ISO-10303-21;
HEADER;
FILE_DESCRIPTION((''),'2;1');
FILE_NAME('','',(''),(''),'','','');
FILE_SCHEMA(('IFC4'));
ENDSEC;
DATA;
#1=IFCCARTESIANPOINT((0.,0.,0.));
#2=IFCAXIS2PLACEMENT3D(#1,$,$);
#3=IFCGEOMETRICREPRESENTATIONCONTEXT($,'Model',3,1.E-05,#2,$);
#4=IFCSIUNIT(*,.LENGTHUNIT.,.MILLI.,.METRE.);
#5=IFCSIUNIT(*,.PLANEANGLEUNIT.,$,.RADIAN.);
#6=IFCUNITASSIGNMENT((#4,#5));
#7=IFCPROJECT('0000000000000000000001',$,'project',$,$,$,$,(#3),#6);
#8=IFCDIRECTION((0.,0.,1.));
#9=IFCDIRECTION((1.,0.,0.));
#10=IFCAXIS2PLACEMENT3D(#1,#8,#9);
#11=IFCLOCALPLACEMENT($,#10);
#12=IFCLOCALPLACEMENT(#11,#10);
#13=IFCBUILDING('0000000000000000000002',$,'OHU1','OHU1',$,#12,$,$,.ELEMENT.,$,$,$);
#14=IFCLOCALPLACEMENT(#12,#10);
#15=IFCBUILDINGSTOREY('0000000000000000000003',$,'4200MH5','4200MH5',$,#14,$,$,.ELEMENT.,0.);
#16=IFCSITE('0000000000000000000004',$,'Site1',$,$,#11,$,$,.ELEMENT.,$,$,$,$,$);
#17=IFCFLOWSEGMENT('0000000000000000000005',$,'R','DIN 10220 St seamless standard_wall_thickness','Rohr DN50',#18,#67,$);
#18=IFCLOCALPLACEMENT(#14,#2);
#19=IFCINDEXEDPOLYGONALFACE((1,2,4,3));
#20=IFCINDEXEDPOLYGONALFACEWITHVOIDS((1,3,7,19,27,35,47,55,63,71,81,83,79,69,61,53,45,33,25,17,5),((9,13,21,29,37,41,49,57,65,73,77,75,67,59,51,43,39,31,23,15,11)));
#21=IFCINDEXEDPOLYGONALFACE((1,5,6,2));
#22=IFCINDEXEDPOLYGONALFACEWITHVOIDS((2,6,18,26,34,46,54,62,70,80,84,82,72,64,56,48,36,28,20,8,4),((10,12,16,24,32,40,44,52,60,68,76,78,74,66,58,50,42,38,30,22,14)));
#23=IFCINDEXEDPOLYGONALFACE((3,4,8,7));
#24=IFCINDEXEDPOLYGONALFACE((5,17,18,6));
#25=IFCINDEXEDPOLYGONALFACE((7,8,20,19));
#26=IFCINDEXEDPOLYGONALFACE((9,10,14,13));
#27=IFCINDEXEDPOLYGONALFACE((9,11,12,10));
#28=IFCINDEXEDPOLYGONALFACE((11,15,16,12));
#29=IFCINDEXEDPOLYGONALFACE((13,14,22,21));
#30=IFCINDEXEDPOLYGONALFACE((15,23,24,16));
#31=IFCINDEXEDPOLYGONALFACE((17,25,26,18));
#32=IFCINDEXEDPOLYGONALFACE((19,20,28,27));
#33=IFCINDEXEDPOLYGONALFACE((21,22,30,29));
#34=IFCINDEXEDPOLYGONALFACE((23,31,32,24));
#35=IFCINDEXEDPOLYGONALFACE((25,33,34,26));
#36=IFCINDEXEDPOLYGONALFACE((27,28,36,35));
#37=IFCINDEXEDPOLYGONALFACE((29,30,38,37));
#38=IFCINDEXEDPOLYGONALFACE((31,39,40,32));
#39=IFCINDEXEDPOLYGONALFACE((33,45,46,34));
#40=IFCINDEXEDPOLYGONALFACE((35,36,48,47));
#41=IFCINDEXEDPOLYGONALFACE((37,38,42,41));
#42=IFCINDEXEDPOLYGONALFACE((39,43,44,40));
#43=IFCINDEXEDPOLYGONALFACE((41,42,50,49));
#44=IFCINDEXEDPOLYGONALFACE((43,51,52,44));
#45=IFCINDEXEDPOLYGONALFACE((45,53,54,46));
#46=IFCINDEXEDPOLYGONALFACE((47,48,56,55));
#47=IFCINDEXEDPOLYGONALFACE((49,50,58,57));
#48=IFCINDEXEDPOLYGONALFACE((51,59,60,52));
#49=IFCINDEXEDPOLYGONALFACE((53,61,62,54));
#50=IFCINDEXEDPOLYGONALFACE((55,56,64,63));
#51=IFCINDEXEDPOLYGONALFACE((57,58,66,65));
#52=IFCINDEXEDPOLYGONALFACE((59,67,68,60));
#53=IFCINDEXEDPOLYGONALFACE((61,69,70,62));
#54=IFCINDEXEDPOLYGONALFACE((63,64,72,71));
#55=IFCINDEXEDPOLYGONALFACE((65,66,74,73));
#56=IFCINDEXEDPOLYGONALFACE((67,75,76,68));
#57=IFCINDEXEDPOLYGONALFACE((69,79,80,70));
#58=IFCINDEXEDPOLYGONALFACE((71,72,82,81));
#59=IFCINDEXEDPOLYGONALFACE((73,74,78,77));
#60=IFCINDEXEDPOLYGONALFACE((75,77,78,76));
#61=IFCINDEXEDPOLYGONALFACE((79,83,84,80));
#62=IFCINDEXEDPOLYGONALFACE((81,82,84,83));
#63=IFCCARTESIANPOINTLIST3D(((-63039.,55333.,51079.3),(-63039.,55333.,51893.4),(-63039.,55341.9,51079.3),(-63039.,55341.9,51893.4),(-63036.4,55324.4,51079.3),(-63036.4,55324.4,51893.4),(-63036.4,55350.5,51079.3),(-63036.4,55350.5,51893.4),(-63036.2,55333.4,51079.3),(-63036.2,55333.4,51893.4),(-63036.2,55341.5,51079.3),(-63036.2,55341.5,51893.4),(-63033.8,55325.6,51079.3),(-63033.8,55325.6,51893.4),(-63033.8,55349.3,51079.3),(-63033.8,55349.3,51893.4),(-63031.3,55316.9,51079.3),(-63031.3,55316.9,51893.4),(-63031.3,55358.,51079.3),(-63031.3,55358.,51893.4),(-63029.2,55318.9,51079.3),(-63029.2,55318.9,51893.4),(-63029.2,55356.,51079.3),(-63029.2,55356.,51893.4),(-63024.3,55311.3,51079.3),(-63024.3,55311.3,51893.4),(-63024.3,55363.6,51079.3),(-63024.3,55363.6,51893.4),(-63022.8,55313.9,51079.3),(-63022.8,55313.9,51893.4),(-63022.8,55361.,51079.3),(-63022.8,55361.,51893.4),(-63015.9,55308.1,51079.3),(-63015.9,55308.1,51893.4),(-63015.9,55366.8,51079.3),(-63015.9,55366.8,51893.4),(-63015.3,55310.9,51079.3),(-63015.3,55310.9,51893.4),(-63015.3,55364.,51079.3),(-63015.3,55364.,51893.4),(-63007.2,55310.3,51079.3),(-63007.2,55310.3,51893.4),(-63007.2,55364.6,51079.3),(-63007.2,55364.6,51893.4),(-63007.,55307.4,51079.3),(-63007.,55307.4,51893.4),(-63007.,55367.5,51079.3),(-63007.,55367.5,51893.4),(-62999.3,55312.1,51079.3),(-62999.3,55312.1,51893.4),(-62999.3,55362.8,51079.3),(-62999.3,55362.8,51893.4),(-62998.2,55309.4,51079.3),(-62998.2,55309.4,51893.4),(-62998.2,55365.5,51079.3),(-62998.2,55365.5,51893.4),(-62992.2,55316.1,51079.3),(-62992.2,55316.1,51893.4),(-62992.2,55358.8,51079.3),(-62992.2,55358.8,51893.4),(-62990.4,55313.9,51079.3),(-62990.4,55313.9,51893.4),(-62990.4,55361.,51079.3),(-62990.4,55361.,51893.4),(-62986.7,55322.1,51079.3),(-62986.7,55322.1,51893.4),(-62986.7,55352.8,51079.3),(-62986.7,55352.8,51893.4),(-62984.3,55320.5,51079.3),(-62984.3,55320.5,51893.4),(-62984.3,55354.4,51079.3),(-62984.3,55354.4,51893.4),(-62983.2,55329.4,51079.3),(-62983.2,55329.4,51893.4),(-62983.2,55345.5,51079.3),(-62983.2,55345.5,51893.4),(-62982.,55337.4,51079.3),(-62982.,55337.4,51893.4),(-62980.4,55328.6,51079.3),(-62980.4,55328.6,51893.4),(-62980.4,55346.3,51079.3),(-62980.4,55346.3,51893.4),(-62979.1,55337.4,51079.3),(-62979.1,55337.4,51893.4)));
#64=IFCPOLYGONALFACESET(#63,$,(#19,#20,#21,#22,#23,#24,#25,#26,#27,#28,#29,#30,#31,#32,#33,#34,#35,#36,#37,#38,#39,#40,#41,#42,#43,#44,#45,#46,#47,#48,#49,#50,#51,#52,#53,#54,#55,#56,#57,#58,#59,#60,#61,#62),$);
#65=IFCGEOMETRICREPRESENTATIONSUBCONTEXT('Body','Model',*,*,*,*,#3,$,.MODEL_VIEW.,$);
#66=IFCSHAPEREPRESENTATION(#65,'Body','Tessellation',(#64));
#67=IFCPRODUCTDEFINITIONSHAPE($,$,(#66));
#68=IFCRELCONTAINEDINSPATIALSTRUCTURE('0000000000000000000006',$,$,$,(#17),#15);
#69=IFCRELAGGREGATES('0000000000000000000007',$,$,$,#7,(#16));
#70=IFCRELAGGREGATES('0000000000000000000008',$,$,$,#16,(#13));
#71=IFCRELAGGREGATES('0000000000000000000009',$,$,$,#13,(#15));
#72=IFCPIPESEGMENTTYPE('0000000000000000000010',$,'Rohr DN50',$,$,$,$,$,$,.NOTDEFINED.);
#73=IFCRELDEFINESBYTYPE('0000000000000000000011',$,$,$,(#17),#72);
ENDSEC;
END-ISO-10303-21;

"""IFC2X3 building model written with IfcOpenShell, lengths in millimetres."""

from ifc_helpers import new_model, si_unit, frame, origin, origin_with_axes, origin_2d_with_axis, place, context, subcontext, project, spatial, hollow_circle, extrude, type_object, element, save


model = new_model("IFC2X3")

# Units and contexts
model_context = context("Model", 3, precision=1e-05, world=origin())
body_context = subcontext(model_context, "Body", "Model", "MODEL_VIEW")
ifc_project = project(units=[si_unit("LENGTHUNIT", "METRE", prefix="MILLI"), si_unit("PLANEANGLEUNIT", "RADIAN")], contexts=[model_context])

# Site, building, storey
site_placement = place(None, origin_with_axes())
site = spatial("IfcSite", under=ifc_project, at=site_placement, Name="Site1", CompositionType="ELEMENT")
building_placement = place(site_placement, origin_with_axes())
building = spatial("IfcBuilding", under=site, at=building_placement, Name="OHU1", Description="OHU1", CompositionType="ELEMENT")
storey_placement = place(building_placement, origin_with_axes())
storey = spatial("IfcBuildingStorey", under=building, at=storey_placement, Name="4200MH5", Description="4200MH5", CompositionType="ELEMENT", Elevation=0.0)

# Flow segment
pipe_segment_type_1 = type_object("IfcPipeSegmentType", Name="Rohr DN50", PredefinedType="NOTDEFINED")
flow_segment_1_placement = place(storey_placement, frame((-63009.2, 55337.4, 51486.3), z_axis=(0.0, 0.0, 1.0), x_axis=(1.0, 0.0, 0.0)))
element("IfcFlowSegment", 1, at=flow_segment_1_placement, inside=storey, type_object=pipe_segment_type_1, Name="R", Description="DIN 10220 St seamless standard_wall_thickness", ObjectType="Rohr DN50", context=body_context, shape_type="SweptSolid", body=[
    extrude(hollow_circle(Radius=30.1, WallThickness=2.9, at=origin_2d_with_axis()), frame((0.0, 0.0, 407.1), z_axis=(0.0, 0.0, -1.0), x_axis=(1.0, 0.0, 0.0)), (0.0, 0.0, 1.0), 814.1),
])

save(model, "model.ifc")
